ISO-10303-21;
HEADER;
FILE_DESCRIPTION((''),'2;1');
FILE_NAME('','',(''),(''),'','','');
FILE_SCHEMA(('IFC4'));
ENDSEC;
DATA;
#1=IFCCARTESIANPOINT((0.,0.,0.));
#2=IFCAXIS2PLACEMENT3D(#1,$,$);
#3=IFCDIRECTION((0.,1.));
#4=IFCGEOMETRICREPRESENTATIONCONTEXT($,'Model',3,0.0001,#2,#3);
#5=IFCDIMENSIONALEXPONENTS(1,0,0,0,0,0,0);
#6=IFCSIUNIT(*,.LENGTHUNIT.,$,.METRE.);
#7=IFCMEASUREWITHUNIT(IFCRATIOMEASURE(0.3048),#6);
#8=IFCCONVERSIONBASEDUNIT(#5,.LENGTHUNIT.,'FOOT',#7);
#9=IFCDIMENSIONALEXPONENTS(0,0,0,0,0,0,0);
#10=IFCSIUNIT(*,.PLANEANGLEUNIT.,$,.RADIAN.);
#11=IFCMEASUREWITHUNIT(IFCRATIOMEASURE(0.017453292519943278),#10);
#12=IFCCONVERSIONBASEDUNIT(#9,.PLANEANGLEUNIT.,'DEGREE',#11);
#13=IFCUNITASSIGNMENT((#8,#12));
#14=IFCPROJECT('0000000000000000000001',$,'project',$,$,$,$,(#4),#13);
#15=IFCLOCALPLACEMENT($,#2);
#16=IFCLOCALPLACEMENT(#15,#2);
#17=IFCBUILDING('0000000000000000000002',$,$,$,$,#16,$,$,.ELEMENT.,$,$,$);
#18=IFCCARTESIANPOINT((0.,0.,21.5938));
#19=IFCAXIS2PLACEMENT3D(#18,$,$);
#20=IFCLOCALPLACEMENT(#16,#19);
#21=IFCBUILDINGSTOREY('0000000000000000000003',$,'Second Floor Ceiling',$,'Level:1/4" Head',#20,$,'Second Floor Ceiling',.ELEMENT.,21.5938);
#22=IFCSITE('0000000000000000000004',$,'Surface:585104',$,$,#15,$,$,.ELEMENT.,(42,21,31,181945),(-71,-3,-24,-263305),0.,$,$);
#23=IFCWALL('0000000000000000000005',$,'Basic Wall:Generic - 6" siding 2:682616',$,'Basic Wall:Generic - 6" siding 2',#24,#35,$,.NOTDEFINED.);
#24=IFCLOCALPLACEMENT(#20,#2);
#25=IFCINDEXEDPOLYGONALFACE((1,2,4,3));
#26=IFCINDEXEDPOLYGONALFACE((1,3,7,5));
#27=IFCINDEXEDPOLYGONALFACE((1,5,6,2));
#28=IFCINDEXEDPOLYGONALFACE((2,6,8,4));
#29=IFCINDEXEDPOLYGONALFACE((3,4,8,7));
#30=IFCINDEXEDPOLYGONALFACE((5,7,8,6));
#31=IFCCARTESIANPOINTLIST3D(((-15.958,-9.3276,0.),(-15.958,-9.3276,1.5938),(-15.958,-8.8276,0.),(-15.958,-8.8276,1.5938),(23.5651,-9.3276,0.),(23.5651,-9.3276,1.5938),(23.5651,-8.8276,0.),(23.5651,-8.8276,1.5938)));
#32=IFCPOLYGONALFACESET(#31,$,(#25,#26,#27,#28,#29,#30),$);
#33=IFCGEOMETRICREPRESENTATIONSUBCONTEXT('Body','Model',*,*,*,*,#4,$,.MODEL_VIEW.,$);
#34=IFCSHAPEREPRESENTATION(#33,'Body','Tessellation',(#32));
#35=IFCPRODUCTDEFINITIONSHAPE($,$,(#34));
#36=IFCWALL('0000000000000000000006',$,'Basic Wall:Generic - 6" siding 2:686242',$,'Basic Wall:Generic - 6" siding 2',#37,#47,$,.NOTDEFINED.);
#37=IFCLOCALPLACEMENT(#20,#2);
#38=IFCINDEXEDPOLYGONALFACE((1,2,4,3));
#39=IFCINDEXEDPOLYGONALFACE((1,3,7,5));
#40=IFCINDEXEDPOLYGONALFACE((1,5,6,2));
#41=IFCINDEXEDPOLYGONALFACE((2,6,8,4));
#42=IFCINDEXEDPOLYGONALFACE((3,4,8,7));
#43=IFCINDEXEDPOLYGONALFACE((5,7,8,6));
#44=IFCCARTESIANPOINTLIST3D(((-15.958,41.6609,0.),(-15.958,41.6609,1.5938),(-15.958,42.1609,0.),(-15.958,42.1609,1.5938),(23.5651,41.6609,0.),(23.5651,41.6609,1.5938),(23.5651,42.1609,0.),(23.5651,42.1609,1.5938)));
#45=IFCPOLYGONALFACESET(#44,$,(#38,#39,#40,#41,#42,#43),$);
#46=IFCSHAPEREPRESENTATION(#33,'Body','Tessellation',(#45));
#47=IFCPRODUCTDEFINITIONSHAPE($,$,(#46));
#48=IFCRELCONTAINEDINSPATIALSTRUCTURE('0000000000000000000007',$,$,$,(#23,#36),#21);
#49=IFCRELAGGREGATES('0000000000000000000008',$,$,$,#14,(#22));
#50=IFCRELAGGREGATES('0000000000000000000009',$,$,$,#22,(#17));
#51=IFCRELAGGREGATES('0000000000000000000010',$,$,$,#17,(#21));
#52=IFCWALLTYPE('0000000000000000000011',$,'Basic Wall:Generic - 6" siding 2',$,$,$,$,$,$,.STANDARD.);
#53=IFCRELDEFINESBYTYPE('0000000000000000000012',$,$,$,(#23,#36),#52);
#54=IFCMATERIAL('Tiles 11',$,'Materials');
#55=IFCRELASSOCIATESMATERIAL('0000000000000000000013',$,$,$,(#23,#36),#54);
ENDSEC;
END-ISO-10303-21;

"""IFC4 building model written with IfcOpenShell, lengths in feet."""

from ifc_helpers import new_model, entity, si_unit, converted_unit, direction, frame, origin, place, context, subcontext, project, spatial, indexed_curve, outline, extrude, material, type_object, element, save


model = new_model("IFC4")

# Units and contexts
model_context = context("Model", 3, precision=0.0001, world=origin(), true_north=direction((0.0, 1.0)))
body_context = subcontext(model_context, "Body", "Model", "MODEL_VIEW")
ifc_project = project(units=[converted_unit("LENGTHUNIT", "FOOT", entity("IfcRatioMeasure", 0.3048), si_unit("LENGTHUNIT", "METRE"), dimensions=[1, 0, 0, 0, 0, 0, 0]), converted_unit("PLANEANGLEUNIT", "DEGREE", entity("IfcRatioMeasure", 0.017453292519943278), si_unit("PLANEANGLEUNIT", "RADIAN"), dimensions=[0, 0, 0, 0, 0, 0, 0])], contexts=[model_context])

# Site, building, storey
site_placement = place(None, origin())
site = spatial("IfcSite", under=ifc_project, at=site_placement, Name="Surface:585104", CompositionType="ELEMENT", RefLatitude=(42, 21, 31, 181945), RefLongitude=(-71, -3, -24, -263305), RefElevation=0.0)
building_placement = place(site_placement, origin())
building = spatial("IfcBuilding", under=site, at=building_placement, CompositionType="ELEMENT")
storey_placement = place(building_placement, frame((0.0, 0.0, 21.5938)))
storey = spatial("IfcBuildingStorey", under=building, at=storey_placement, Name="Second Floor Ceiling", ObjectType="Level:1/4\" Head", LongName="Second Floor Ceiling", CompositionType="ELEMENT", Elevation=21.5938)

# Walls
ifc_material_1 = material(Name="Tiles 11", Category="Materials")
wall_type_1 = type_object("IfcWallType", Name="Basic Wall:Generic - 6\" siding 2", PredefinedType="STANDARD")
wall_1_placement = place(storey_placement, frame((-15.958, -9.0776, 0.0)))
element("IfcWall", 1, at=wall_1_placement, inside=storey, type_object=wall_type_1, material=ifc_material_1, Name="Basic Wall:Generic - 6\" siding 2:682616", ObjectType="Basic Wall:Generic - 6\" siding 2", PredefinedType="NOTDEFINED", context=body_context, shape_type="SweptSolid", body=[
    extrude(outline(indexed_curve([(-19.7615, -0.25), (19.7615, -0.25), (19.7615, 0.25), (-19.7615, 0.25), (-19.7615, -0.25)], self_intersect=False)), frame((19.7615, 0.0, 0.0)), (0.0, 0.0, 1.0), 1.5938),
])
wall_2_placement = place(storey_placement, frame((-15.958, 41.9109, 0.0)))
element("IfcWall", 2, at=wall_2_placement, inside=storey, type_object=wall_type_1, material=ifc_material_1, Name="Basic Wall:Generic - 6\" siding 2:686242", ObjectType="Basic Wall:Generic - 6\" siding 2", PredefinedType="NOTDEFINED", context=body_context, shape_type="SweptSolid", body=[
    extrude(outline(indexed_curve([(-19.7615, -0.25), (19.7615, -0.25), (19.7615, 0.25), (-19.7615, 0.25), (-19.7615, -0.25)], self_intersect=False)), frame((19.7615, 0.0, 0.0)), (0.0, 0.0, 1.0), 1.5938),
])

save(model, "model.ifc")
